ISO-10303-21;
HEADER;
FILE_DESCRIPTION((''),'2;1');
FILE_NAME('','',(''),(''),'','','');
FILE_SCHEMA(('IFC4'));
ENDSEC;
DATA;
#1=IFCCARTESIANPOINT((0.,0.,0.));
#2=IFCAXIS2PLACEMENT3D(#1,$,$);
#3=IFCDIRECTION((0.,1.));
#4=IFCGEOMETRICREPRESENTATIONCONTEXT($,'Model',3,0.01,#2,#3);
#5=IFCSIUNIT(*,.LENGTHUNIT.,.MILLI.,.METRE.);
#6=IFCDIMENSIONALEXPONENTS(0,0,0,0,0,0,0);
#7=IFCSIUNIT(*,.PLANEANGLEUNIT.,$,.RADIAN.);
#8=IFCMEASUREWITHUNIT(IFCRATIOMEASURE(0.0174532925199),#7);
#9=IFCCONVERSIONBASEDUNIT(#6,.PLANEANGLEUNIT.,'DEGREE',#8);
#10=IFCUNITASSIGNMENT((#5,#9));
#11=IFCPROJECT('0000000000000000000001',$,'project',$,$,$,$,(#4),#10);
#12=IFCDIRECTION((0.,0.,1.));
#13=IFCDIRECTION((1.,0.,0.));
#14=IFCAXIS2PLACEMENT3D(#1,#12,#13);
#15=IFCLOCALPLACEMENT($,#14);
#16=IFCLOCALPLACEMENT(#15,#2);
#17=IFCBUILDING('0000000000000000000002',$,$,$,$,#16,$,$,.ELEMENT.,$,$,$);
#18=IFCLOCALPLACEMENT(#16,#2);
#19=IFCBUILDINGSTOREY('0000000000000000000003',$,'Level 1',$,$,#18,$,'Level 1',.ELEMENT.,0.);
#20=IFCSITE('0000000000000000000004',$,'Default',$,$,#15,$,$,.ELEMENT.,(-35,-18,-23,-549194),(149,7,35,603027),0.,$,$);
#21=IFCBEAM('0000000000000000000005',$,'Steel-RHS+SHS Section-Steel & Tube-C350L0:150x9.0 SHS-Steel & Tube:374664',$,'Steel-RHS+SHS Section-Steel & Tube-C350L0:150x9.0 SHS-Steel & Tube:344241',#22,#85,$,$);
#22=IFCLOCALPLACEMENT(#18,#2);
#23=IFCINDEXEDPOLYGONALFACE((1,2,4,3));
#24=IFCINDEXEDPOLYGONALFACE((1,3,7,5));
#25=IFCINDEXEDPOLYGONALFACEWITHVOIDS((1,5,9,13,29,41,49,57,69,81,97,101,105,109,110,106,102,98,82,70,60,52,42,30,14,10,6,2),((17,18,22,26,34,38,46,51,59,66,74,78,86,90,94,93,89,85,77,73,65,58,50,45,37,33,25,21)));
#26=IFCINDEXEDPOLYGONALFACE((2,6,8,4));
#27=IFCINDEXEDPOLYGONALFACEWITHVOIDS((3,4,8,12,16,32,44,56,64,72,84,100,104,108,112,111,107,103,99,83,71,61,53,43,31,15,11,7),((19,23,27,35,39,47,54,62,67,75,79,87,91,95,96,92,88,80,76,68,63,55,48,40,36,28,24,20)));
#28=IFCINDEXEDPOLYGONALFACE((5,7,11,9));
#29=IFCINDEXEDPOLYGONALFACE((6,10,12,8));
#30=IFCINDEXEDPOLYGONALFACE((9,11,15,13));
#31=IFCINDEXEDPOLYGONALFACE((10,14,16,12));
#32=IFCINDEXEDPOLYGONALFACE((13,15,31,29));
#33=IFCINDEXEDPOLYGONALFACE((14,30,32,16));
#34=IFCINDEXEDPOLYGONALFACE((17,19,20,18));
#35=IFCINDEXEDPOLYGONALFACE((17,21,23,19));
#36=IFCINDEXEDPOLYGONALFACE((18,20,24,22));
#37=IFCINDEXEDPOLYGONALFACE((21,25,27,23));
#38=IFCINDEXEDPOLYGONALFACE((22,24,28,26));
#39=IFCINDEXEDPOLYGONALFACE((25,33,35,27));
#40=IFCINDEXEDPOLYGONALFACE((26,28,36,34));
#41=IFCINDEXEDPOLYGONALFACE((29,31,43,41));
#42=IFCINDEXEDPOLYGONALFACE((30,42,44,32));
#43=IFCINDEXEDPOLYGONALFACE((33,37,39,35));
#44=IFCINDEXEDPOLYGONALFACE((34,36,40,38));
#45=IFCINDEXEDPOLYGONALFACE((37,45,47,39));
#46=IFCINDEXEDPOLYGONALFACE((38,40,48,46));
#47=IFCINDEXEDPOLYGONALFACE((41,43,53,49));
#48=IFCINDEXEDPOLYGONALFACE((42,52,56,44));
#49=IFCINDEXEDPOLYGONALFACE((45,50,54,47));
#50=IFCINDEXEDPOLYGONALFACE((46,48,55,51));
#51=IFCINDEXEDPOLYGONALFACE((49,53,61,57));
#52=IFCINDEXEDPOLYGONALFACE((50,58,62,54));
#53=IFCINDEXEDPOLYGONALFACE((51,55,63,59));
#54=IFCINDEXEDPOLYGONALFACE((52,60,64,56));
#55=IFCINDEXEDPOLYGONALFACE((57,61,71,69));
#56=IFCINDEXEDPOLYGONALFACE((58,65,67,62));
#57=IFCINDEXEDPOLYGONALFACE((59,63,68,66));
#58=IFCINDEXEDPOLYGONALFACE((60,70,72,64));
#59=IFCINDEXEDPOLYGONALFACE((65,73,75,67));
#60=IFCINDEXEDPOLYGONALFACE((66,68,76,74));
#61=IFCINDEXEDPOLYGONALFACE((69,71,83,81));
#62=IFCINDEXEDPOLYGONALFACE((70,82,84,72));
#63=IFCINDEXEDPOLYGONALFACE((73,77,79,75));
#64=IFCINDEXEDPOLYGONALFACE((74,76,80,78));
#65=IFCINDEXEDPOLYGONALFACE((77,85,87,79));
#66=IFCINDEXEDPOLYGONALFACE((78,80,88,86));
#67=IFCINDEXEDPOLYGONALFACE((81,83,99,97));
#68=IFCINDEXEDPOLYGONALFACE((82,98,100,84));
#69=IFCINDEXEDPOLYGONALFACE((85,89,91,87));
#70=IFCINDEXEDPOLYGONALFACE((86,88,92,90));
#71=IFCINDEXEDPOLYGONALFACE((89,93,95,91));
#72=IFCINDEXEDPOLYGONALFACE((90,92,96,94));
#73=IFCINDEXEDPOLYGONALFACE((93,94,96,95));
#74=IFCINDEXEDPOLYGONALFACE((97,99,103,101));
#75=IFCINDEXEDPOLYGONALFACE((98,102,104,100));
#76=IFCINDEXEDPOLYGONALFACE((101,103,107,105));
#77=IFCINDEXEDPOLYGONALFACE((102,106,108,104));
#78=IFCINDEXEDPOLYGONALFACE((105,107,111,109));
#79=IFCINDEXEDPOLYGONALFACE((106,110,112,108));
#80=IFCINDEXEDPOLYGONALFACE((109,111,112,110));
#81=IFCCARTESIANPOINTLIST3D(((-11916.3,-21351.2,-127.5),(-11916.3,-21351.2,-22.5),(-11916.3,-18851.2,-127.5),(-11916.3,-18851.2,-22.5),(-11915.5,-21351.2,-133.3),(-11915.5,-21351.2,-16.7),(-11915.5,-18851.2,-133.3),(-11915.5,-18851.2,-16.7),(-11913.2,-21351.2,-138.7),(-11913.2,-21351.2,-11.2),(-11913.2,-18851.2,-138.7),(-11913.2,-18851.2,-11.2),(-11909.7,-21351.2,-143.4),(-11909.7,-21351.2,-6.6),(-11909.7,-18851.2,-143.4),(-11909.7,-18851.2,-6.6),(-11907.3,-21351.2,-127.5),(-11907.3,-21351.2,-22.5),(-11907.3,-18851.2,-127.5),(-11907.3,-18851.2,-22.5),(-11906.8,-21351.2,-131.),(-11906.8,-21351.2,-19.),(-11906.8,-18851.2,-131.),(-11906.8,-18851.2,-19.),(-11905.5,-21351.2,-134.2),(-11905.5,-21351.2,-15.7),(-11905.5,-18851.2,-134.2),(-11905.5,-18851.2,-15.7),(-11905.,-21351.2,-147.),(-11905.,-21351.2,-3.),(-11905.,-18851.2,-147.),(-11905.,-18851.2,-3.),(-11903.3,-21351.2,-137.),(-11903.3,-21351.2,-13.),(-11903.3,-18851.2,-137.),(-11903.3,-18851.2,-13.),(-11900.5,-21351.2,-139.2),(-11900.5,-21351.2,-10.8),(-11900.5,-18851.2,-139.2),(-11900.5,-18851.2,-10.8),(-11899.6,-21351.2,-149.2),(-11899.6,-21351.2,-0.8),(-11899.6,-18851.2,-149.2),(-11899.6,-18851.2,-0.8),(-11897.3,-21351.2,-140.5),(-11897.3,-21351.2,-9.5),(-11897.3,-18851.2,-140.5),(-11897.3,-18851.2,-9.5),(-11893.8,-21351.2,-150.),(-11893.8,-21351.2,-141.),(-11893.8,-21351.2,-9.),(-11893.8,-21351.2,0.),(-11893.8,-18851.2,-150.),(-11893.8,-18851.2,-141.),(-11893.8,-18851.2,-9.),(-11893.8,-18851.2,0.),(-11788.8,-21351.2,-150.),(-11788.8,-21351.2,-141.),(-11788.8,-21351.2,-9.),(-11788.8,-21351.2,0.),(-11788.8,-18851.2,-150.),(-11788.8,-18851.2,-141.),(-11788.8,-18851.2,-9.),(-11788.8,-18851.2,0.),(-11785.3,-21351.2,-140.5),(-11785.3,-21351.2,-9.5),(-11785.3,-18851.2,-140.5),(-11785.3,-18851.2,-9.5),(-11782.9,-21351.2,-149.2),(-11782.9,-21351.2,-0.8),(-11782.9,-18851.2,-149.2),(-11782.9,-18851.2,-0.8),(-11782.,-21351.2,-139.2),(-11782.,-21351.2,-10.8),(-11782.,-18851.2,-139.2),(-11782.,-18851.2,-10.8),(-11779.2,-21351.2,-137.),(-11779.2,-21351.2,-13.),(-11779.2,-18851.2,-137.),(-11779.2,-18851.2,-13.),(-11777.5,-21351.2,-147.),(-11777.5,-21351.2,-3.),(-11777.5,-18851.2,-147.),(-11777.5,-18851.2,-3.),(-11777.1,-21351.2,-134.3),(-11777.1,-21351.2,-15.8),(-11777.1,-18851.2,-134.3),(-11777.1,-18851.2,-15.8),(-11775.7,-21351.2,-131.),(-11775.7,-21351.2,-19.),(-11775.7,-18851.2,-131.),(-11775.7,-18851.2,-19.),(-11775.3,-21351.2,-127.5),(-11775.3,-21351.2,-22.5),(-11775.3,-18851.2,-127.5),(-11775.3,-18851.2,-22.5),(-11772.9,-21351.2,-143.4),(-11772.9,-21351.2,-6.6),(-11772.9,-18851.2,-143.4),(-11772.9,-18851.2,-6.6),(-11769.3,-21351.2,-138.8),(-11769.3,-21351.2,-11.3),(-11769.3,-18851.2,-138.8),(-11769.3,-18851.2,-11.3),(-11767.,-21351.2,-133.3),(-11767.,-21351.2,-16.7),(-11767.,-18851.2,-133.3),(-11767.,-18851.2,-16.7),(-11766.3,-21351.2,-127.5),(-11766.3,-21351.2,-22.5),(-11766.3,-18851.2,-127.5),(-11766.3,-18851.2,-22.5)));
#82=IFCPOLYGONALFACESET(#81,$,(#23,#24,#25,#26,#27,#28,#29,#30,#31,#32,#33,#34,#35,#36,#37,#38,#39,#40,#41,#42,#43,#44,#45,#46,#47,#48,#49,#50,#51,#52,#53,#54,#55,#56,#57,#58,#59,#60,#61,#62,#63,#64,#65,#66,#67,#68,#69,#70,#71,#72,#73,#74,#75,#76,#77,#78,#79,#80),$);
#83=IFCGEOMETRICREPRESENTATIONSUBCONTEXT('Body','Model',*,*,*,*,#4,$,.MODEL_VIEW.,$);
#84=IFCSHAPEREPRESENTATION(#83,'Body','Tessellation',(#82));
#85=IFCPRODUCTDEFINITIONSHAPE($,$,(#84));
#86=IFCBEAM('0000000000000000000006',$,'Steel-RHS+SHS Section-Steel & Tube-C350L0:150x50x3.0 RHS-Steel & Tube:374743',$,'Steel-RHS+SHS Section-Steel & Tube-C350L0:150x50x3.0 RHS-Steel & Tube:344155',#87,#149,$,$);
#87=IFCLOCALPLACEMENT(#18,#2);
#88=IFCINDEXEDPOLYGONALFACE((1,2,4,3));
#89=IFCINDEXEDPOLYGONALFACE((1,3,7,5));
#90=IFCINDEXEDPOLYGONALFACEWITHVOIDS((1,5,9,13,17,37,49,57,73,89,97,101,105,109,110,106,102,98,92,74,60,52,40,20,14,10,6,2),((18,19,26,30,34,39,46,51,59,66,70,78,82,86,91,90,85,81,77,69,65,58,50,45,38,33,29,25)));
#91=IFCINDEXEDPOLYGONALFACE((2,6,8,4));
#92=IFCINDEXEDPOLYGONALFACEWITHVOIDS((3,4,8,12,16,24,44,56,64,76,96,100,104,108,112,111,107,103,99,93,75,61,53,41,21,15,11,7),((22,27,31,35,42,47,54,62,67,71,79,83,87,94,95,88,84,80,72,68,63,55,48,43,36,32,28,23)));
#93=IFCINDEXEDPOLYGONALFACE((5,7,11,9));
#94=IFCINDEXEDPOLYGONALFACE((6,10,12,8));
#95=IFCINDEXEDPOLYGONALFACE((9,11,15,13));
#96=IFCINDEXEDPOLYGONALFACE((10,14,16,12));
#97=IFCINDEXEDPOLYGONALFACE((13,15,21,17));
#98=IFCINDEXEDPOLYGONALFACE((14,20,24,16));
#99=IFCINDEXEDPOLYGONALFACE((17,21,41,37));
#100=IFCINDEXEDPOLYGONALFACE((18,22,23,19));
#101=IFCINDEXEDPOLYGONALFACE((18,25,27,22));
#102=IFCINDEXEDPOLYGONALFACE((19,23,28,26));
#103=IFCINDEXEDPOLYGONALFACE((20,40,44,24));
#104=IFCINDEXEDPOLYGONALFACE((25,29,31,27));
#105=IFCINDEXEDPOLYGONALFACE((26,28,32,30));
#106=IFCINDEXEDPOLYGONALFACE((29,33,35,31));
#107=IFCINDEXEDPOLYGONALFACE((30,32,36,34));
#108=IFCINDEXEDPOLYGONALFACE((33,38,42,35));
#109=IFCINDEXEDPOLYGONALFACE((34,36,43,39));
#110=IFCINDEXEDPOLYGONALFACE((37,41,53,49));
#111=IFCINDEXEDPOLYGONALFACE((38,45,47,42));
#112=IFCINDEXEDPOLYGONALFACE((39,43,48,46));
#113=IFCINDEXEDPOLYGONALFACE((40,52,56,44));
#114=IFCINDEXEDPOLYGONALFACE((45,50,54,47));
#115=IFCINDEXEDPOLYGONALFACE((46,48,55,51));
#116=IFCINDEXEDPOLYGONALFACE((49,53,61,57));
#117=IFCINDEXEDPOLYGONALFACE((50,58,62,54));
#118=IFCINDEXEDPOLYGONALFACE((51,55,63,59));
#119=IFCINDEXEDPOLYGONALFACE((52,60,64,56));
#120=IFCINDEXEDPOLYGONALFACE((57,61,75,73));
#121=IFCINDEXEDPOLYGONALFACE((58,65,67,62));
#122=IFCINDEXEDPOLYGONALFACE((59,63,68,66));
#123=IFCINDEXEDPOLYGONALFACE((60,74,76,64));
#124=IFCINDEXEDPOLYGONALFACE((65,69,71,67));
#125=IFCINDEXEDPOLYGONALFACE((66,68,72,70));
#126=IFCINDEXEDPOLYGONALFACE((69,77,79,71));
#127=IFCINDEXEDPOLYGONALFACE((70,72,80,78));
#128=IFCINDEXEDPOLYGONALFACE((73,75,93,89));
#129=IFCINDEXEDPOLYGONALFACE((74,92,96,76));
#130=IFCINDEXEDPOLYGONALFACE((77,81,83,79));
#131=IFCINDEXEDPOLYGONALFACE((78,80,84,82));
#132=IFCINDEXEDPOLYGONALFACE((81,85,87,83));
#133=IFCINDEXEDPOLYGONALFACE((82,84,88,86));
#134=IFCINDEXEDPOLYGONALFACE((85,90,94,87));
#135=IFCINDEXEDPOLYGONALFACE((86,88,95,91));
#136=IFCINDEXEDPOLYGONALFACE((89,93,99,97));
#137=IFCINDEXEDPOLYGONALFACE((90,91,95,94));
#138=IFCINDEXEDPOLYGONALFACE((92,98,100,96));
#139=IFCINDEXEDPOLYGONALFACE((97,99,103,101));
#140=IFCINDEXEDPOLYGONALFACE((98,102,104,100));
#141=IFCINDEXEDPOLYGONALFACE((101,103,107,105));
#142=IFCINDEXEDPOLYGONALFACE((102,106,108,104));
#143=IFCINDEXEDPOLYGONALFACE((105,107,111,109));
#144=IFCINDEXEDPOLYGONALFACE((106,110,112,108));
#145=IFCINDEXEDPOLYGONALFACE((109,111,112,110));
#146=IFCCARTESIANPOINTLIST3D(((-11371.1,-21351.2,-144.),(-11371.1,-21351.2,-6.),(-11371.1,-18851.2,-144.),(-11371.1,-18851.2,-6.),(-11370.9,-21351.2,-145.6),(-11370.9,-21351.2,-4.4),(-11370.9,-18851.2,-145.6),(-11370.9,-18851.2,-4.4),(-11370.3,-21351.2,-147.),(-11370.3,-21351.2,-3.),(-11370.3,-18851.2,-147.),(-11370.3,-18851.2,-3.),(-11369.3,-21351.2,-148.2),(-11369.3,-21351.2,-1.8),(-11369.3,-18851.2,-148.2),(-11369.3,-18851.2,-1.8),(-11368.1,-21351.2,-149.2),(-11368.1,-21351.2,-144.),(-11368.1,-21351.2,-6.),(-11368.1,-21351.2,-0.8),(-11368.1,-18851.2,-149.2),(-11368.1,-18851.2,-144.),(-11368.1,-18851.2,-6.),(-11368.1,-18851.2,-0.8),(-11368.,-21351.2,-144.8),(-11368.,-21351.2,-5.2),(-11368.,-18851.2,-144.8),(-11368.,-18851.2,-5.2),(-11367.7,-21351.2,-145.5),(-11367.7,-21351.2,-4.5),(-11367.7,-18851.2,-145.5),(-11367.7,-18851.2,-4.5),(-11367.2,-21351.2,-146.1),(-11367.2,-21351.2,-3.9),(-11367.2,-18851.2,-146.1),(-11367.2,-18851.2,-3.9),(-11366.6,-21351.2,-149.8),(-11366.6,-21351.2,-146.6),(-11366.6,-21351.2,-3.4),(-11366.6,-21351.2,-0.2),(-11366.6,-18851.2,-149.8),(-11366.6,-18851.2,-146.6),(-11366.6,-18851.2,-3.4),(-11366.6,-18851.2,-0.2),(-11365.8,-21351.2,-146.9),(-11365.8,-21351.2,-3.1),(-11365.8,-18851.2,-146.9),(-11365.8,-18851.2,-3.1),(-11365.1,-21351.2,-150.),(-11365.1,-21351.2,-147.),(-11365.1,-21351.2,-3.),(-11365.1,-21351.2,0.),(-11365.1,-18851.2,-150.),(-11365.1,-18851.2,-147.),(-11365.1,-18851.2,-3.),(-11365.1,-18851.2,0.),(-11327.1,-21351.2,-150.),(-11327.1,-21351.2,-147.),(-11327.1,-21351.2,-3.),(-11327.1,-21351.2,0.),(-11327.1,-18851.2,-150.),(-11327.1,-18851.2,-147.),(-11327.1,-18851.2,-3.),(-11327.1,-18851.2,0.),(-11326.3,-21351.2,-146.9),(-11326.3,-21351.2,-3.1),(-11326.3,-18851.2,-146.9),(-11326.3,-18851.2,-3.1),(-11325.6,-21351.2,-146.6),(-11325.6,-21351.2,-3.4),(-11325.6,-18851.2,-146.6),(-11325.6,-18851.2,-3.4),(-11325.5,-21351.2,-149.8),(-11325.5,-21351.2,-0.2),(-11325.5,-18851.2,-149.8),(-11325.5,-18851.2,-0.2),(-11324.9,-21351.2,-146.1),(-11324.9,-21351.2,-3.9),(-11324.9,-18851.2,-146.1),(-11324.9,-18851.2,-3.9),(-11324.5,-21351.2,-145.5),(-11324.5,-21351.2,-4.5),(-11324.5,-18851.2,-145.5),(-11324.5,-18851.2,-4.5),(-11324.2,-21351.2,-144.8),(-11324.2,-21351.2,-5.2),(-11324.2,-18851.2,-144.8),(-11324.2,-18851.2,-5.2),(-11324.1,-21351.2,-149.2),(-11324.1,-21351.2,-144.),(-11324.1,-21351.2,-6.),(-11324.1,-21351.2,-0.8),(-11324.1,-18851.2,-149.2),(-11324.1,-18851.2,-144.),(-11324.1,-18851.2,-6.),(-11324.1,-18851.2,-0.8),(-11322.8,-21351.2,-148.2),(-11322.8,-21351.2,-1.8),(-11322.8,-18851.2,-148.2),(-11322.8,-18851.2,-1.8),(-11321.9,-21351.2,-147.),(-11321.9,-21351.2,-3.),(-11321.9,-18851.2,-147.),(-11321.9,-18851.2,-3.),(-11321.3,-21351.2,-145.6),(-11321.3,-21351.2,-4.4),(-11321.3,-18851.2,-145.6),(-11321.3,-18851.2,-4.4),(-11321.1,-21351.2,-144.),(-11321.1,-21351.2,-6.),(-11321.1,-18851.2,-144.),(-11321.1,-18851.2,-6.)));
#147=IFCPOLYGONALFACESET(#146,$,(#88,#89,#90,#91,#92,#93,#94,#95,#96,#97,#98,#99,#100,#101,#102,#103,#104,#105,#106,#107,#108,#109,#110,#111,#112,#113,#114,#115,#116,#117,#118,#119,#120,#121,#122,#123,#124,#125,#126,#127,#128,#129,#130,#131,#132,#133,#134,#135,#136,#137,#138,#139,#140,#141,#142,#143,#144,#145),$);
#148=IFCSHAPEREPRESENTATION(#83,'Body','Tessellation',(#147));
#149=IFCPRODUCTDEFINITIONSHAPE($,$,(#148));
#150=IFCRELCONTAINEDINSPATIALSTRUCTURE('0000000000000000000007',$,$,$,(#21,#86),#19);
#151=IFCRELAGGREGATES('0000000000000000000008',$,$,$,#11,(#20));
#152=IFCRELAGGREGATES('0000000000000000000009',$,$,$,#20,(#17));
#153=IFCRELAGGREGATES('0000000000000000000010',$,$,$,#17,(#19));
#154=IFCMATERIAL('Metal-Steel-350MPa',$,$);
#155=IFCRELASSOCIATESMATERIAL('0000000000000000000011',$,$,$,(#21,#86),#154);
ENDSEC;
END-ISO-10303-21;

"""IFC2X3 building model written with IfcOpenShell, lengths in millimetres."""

from ifc_helpers import new_model, entity, si_unit, converted_unit, direction, frame, frame_2d, origin, origin_with_axes, place, context, subcontext, project, spatial, polyline, circle_curve, parameter, trimmed, segment, composite_curve, outline, extrude, material, element, save


model = new_model("IFC2X3")

# Units and contexts
model_context = context("Model", 3, precision=0.01, world=origin(), true_north=direction((0.0, 1.0)))
body_context = subcontext(model_context, "Body", "Model", "MODEL_VIEW")
ifc_project = project(units=[si_unit("LENGTHUNIT", "METRE", prefix="MILLI"), converted_unit("PLANEANGLEUNIT", "DEGREE", entity("IfcRatioMeasure", 0.0174532925199), si_unit("PLANEANGLEUNIT", "RADIAN"), dimensions=[0, 0, 0, 0, 0, 0, 0])], contexts=[model_context])

# Site, building, storey
site_placement = place(None, origin_with_axes())
site = spatial("IfcSite", under=ifc_project, at=site_placement, Name="Default", CompositionType="ELEMENT", RefLatitude=(-35, -18, -23, -549194), RefLongitude=(149, 7, 35, 603027), RefElevation=0.0)
building_placement = place(site_placement, origin())
building = spatial("IfcBuilding", under=site, at=building_placement, CompositionType="ELEMENT")
storey_placement = place(building_placement, origin())
storey = spatial("IfcBuildingStorey", under=building, at=storey_placement, Name="Level 1", LongName="Level 1", CompositionType="ELEMENT", Elevation=0.0)

# Beams
ifc_material = material(Name="Metal-Steel-350MPa")
beam_1_placement = place(storey_placement, frame((-11841.3, -18851.2, 0.0), z_axis=(0.0, 0.0, 1.0), x_axis=(0.0, -1.0, 0.0)))
element("IfcBeam", 1, at=beam_1_placement, inside=storey, material=ifc_material, Name="Steel-RHS+SHS Section-Steel & Tube-C350L0:150x9.0 SHS-Steel & Tube:374664", ObjectType="Steel-RHS+SHS Section-Steel & Tube-C350L0:150x9.0 SHS-Steel & Tube:344241", context=body_context, shape_type="SweptSolid", body=[
    extrude(outline(composite_curve([segment(trimmed(circle_curve(frame_2d((-52.5, -52.5), x_axis=(1.0, 0.0)), 22.5), [parameter(180.0)], [parameter(270.0)], True, "PARAMETER"), True, "CONTINUOUS"), segment(polyline([(-52.5, -75.0), (52.5, -75.0)]), True, "CONTINUOUS"), segment(trimmed(circle_curve(frame_2d((52.5, -52.5), x_axis=(1.0, 0.0)), 22.5), [parameter(270.0)], [parameter(0.0)], True, "PARAMETER"), True, "CONTINUOUS"), segment(polyline([(75.0, -52.5), (75.0, 52.5)]), True, "CONTINUOUS"), segment(trimmed(circle_curve(frame_2d((52.5, 52.5), x_axis=(1.0, 0.0)), 22.5), [parameter(0.0)], [parameter(90.0)], True, "PARAMETER"), True, "CONTINUOUS"), segment(polyline([(52.5, 75.0), (-52.5, 75.0)]), True, "CONTINUOUS"), segment(trimmed(circle_curve(frame_2d((-52.5, 52.5), x_axis=(1.0, 0.0)), 22.5), [parameter(90.0)], [parameter(180.0)], True, "PARAMETER"), True, "CONTINUOUS"), segment(polyline([(-75.0, 52.5), (-75.0, -52.5)]), True, "CONTINUOUS")], self_intersect=False), holes=[composite_curve([segment(polyline([(52.5, -66.0), (-52.5, -66.0)]), True, "CONTINUOUS"), segment(trimmed(circle_curve(frame_2d((-52.5, -52.5), x_axis=(1.0, 0.0)), 13.5), [parameter(180.0)], [parameter(270.0)], True, "PARAMETER"), False, "CONTINUOUS"), segment(polyline([(-66.0, -52.5), (-66.0, 52.5)]), True, "CONTINUOUS"), segment(trimmed(circle_curve(frame_2d((-52.5, 52.5), x_axis=(1.0, 0.0)), 13.5), [parameter(90.0)], [parameter(180.0)], True, "PARAMETER"), False, "CONTINUOUS"), segment(polyline([(-52.5, 66.0), (52.5, 66.0)]), True, "CONTINUOUS"), segment(trimmed(circle_curve(frame_2d((52.5, 52.5), x_axis=(1.0, 0.0)), 13.5), [parameter(360.0)], [parameter(90.0)], True, "PARAMETER"), False, "CONTINUOUS"), segment(polyline([(66.0, 52.5), (66.0, -52.5)]), True, "CONTINUOUS"), segment(trimmed(circle_curve(frame_2d((52.5, -52.5), x_axis=(1.0, 0.0)), 13.5), [parameter(270.0)], [parameter(0.0)], True, "PARAMETER"), False, "CONTINUOUS")], self_intersect=False)]), frame((0.0, 0.0, -75.0), z_axis=(1.0, 0.0, 0.0), x_axis=(0.0, -1.0, 0.0)), (0.0, 0.0, 1.0), 2500.0),
])
beam_2_placement = place(storey_placement, frame((-11346.1, -18851.2, 0.0), z_axis=(0.0, 0.0, 1.0), x_axis=(0.0, -1.0, 0.0)))
element("IfcBeam", 2, at=beam_2_placement, inside=storey, material=ifc_material, Name="Steel-RHS+SHS Section-Steel & Tube-C350L0:150x50x3.0 RHS-Steel & Tube:374743", ObjectType="Steel-RHS+SHS Section-Steel & Tube-C350L0:150x50x3.0 RHS-Steel & Tube:344155", context=body_context, shape_type="SweptSolid", body=[
    extrude(outline(composite_curve([segment(trimmed(circle_curve(frame_2d((-19.0, -69.0), x_axis=(1.0, 0.0)), 6.0), [parameter(180.0)], [parameter(270.0)], True, "PARAMETER"), True, "CONTINUOUS"), segment(polyline([(-19.0, -75.0), (19.0, -75.0)]), True, "CONTINUOUS"), segment(trimmed(circle_curve(frame_2d((19.0, -69.0), x_axis=(1.0, 0.0)), 6.0), [parameter(270.0)], [parameter(0.0)], True, "PARAMETER"), True, "CONTINUOUS"), segment(polyline([(25.0, -69.0), (25.0, 69.0)]), True, "CONTINUOUS"), segment(trimmed(circle_curve(frame_2d((19.0, 69.0), x_axis=(1.0, 0.0)), 6.0), [parameter(0.0)], [parameter(90.0)], True, "PARAMETER"), True, "CONTINUOUS"), segment(polyline([(19.0, 75.0), (-19.0, 75.0)]), True, "CONTINUOUS"), segment(trimmed(circle_curve(frame_2d((-19.0, 69.0), x_axis=(1.0, 0.0)), 6.0), [parameter(90.0)], [parameter(180.0)], True, "PARAMETER"), True, "CONTINUOUS"), segment(polyline([(-25.0, 69.0), (-25.0, -69.0)]), True, "CONTINUOUS")], self_intersect=False), holes=[composite_curve([segment(polyline([(19.0, -72.0), (-19.0, -72.0)]), True, "CONTINUOUS"), segment(trimmed(circle_curve(frame_2d((-19.0, -69.0), x_axis=(1.0, 0.0)), 3.0), [parameter(180.0)], [parameter(270.0)], True, "PARAMETER"), False, "CONTINUOUS"), segment(polyline([(-22.0, -69.0), (-22.0, 69.0)]), True, "CONTINUOUS"), segment(trimmed(circle_curve(frame_2d((-19.0, 69.0), x_axis=(1.0, 0.0)), 3.0), [parameter(90.0)], [parameter(180.0)], True, "PARAMETER"), False, "CONTINUOUS"), segment(polyline([(-19.0, 72.0), (19.0, 72.0)]), True, "CONTINUOUS"), segment(trimmed(circle_curve(frame_2d((19.0, 69.0), x_axis=(1.0, 0.0)), 3.0), [parameter(360.0)], [parameter(90.0)], True, "PARAMETER"), False, "CONTINUOUS"), segment(polyline([(22.0, 69.0), (22.0, -69.0)]), True, "CONTINUOUS"), segment(trimmed(circle_curve(frame_2d((19.0, -69.0), x_axis=(1.0, 0.0)), 3.0), [parameter(270.0)], [parameter(0.0)], True, "PARAMETER"), False, "CONTINUOUS")], self_intersect=False)]), frame((0.0, 0.0, -75.0), z_axis=(1.0, 0.0, 0.0), x_axis=(0.0, -1.0, 0.0)), (0.0, 0.0, 1.0), 2500.0),
])

save(model, "model.ifc")
